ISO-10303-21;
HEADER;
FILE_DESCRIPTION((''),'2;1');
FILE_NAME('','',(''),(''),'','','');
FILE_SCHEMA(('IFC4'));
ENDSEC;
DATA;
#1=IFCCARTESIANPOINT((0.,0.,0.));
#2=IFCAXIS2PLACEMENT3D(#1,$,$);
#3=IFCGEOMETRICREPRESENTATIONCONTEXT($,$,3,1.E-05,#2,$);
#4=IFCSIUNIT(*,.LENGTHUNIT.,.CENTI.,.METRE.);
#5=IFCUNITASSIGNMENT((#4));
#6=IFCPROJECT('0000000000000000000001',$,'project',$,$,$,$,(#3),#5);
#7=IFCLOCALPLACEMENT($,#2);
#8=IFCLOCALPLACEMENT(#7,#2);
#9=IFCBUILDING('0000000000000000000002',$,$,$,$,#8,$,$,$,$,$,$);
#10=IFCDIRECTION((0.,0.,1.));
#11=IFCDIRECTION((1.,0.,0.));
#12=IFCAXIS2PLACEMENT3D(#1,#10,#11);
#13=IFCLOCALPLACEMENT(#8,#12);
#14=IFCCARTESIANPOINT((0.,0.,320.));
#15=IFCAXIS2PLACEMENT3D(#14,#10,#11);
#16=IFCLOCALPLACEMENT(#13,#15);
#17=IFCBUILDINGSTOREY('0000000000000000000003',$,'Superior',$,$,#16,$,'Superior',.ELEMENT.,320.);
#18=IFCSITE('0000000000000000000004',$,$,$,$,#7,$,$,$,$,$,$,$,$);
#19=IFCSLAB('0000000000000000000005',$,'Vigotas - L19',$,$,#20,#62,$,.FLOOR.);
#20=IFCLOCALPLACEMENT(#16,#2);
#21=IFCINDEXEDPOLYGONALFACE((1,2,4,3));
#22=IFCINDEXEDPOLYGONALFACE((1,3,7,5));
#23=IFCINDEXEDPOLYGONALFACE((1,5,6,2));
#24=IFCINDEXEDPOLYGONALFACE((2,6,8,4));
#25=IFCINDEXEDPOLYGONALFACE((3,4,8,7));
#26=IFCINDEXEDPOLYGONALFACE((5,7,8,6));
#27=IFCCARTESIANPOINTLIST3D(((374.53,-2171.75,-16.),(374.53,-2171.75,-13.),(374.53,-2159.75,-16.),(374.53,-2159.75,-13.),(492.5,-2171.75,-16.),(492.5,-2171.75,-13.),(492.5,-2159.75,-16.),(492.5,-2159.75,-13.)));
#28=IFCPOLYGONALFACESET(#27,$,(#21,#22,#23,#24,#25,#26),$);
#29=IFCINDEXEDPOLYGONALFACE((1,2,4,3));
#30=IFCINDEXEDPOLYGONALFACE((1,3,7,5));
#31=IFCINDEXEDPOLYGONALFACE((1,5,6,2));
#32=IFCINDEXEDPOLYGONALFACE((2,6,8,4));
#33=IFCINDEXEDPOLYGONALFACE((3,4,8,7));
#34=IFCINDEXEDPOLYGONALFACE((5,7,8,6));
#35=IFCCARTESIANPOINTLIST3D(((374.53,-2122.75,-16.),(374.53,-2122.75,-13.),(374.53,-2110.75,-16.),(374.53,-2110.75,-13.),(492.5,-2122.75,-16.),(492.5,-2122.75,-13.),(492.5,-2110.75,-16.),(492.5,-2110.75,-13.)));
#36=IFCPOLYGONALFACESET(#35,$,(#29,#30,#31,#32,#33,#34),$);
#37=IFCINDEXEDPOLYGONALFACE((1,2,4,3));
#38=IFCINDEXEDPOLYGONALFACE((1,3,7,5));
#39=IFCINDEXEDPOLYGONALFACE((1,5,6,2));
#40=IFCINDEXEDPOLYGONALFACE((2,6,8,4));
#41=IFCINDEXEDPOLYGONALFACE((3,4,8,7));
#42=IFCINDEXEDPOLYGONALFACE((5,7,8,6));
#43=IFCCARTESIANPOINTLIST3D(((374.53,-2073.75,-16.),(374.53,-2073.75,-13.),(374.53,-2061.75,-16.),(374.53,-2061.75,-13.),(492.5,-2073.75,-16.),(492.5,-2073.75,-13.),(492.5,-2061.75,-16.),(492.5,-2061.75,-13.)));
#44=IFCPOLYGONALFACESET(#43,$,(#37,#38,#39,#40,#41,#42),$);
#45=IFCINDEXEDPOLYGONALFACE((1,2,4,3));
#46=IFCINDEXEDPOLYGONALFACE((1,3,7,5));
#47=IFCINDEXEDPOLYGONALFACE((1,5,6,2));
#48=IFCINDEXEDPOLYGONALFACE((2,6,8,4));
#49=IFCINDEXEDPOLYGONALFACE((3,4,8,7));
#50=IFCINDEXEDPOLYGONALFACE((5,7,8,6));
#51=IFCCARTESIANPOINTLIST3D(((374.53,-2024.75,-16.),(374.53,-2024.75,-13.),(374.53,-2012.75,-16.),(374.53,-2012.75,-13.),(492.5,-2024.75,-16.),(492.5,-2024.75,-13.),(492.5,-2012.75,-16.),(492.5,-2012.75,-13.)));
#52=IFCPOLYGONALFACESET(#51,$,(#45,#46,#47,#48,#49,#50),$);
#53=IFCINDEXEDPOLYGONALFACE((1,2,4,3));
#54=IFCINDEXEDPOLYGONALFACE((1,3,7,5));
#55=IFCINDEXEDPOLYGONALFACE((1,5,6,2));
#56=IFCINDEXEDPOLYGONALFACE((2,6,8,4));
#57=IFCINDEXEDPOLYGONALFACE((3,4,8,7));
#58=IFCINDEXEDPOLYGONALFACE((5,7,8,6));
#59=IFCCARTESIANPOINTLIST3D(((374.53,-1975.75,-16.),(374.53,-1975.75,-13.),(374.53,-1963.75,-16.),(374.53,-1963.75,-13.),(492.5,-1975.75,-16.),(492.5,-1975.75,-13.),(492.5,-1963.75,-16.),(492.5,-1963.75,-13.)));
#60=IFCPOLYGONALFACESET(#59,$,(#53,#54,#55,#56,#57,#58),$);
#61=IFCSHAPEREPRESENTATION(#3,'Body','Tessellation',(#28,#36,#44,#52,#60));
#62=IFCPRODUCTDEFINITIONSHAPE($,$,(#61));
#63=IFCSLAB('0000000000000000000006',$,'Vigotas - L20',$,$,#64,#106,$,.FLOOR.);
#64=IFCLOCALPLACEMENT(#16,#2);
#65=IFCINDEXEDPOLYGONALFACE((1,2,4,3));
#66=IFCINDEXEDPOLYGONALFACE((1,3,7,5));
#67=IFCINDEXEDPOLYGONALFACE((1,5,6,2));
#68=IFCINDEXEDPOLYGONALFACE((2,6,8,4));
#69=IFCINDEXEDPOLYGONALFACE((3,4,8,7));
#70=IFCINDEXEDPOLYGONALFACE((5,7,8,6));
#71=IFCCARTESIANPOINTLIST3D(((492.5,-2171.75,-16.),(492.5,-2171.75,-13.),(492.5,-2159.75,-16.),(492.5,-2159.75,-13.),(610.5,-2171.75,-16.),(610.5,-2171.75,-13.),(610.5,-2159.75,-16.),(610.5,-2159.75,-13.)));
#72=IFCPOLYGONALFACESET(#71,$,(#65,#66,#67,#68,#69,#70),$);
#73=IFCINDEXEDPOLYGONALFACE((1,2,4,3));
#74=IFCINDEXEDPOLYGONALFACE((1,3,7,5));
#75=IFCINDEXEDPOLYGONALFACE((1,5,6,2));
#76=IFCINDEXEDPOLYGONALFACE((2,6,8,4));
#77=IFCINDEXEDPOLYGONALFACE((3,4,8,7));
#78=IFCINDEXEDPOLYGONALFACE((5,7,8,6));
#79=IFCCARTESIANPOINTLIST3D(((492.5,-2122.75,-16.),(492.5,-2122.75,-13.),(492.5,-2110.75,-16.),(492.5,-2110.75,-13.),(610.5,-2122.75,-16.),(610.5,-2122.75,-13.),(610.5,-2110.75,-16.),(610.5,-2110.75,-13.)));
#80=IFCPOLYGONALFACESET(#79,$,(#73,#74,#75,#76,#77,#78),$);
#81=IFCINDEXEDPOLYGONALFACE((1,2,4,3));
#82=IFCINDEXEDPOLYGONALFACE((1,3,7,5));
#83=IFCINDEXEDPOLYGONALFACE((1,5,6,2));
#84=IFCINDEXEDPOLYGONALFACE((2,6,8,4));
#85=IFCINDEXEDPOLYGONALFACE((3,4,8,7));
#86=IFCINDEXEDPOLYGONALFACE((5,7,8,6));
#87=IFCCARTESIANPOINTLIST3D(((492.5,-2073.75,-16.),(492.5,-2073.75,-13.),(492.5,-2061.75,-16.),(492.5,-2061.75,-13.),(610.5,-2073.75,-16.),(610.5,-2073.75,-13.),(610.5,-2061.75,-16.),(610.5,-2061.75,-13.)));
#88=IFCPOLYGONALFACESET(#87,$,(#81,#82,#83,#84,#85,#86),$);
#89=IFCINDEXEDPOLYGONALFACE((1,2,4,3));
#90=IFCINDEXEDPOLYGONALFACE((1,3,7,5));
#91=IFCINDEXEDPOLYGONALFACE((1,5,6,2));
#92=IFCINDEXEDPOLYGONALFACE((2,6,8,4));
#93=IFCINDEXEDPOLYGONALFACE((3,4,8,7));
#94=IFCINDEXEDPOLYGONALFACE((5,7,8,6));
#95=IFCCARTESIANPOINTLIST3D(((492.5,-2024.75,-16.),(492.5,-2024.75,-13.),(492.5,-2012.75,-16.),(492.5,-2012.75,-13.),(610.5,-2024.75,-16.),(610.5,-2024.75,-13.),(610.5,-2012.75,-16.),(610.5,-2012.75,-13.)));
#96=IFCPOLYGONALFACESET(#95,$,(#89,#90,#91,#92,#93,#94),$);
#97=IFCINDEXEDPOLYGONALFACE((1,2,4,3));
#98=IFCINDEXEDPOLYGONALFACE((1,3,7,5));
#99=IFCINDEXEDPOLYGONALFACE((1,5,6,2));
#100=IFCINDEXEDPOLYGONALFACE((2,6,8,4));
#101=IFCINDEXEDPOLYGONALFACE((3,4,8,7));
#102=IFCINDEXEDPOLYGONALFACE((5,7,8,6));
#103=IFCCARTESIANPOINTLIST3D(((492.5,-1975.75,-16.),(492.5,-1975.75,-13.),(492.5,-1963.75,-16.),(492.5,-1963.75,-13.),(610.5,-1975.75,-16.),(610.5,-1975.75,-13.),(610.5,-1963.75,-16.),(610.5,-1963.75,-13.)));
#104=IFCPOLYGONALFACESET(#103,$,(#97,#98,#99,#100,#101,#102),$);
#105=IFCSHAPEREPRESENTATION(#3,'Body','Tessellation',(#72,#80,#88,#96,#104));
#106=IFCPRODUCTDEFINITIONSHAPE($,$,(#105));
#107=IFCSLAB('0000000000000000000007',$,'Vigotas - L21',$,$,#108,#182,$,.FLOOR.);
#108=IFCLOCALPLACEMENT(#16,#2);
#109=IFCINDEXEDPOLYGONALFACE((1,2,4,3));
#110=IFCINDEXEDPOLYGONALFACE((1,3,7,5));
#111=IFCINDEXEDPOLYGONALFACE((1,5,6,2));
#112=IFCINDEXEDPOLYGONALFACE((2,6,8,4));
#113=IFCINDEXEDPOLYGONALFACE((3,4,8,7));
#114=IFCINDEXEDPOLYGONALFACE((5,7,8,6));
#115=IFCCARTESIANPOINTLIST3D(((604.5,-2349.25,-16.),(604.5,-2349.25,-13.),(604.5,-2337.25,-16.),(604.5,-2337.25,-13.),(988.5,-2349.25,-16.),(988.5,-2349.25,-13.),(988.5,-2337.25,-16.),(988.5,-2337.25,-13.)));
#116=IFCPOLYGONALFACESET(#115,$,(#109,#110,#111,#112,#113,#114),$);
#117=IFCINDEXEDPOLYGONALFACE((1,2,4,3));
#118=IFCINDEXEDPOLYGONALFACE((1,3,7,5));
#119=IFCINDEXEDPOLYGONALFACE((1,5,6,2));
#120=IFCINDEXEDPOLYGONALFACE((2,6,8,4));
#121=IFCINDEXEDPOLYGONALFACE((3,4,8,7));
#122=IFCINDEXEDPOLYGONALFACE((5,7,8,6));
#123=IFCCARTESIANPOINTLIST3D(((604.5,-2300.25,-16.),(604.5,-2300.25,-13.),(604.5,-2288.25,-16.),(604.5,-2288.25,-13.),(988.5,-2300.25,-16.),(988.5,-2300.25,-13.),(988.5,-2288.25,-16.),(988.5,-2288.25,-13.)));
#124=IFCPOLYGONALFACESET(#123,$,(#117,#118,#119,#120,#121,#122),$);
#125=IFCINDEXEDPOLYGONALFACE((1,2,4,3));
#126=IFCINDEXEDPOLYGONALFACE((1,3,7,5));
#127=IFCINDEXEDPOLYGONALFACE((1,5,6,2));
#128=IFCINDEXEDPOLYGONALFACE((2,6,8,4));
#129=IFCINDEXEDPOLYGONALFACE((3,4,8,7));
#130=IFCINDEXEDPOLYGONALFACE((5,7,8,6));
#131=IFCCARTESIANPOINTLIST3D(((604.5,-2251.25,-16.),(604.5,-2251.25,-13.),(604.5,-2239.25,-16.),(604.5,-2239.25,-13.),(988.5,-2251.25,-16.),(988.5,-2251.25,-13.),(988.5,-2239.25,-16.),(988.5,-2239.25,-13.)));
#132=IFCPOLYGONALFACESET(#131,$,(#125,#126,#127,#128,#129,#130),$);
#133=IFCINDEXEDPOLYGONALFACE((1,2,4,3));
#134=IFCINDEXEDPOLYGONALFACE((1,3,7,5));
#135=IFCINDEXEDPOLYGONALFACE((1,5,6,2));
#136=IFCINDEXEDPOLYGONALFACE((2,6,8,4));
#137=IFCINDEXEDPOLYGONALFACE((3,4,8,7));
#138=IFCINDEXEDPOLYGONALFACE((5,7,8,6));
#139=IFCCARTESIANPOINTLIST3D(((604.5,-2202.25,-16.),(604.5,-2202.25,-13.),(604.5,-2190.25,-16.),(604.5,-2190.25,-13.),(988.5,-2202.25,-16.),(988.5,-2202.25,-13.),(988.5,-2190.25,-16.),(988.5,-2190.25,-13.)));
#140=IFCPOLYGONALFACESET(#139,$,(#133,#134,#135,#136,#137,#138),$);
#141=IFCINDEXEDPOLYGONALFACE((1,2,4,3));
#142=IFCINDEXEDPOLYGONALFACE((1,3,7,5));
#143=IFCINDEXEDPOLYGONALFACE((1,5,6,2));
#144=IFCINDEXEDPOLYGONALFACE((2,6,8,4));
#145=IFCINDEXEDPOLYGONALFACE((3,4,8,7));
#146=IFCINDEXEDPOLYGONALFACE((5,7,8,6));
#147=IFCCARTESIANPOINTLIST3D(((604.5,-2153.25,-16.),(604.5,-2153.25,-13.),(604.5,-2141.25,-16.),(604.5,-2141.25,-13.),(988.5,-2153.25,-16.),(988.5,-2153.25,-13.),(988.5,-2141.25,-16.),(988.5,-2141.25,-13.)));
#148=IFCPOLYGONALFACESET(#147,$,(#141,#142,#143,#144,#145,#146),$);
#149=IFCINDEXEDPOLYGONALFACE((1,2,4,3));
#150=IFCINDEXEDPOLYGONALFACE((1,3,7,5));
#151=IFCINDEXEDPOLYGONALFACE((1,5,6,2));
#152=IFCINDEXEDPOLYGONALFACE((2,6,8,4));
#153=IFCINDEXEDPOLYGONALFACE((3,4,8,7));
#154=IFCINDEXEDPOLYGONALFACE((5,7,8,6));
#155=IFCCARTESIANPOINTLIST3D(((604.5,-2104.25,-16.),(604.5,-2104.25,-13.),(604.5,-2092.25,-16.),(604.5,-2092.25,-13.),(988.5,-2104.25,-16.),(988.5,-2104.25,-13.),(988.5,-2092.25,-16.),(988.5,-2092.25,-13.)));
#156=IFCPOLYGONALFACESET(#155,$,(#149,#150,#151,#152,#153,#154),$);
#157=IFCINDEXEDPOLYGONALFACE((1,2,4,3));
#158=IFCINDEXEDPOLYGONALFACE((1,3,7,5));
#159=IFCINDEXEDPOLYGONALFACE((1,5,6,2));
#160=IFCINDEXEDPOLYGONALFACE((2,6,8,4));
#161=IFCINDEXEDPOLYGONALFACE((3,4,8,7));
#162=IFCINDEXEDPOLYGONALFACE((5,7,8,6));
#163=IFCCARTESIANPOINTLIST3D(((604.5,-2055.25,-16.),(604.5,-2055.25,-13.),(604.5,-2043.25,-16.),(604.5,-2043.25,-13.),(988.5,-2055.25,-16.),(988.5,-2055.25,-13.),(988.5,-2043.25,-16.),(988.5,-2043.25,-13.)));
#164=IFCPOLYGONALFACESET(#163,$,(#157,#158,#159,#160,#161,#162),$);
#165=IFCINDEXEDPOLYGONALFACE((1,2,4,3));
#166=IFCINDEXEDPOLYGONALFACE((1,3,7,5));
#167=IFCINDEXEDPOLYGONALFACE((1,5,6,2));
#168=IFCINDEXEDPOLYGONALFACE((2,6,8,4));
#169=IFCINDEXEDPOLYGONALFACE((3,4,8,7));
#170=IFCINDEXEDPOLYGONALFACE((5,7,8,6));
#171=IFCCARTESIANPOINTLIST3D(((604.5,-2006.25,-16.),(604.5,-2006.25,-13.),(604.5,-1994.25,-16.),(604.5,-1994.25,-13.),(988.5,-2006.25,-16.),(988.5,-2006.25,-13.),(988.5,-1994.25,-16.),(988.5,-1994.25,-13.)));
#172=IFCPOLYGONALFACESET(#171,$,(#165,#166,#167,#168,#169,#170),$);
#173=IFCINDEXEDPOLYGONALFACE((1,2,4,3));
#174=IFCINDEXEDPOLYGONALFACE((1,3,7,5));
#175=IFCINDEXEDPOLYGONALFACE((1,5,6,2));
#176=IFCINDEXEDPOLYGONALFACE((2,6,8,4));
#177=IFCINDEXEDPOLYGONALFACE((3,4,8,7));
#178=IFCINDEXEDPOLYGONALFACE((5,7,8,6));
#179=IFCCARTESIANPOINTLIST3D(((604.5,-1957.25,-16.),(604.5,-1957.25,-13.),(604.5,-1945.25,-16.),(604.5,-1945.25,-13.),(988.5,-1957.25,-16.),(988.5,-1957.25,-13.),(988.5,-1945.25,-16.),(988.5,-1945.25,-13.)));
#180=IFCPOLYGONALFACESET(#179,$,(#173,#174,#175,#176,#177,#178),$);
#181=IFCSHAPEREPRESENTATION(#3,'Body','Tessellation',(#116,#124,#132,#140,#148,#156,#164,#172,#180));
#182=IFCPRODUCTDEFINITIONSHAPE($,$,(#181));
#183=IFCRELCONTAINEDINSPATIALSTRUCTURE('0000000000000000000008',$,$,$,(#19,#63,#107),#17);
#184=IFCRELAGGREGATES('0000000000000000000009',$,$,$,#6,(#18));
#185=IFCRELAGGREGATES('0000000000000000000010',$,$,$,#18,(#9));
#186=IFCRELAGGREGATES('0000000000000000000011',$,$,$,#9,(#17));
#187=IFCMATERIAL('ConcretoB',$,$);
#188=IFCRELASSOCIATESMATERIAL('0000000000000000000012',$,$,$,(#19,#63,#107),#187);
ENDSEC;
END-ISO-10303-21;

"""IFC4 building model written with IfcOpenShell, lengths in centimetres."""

from ifc_helpers import new_model, si_unit, frame, origin, origin_with_axes, place, context, project, spatial, polyline, outline, extrude, material, element, save


model = new_model("IFC4")

# Units and contexts
context_of_model = context(None, 3, precision=1e-05, world=origin())
ifc_project = project(units=[si_unit("LENGTHUNIT", "METRE", prefix="CENTI")], contexts=[context_of_model])

# Site, building, storey
site_placement = place(None, origin())
site = spatial("IfcSite", under=ifc_project, at=site_placement)
building_placement = place(site_placement, origin())
building = spatial("IfcBuilding", under=site, at=building_placement)
placement = place(building_placement, origin_with_axes())
storey_placement = place(placement, frame((0.0, 0.0, 320.0), z_axis=(0.0, 0.0, 1.0), x_axis=(1.0, 0.0, 0.0)))
storey = spatial("IfcBuildingStorey", under=building, at=storey_placement, Name="Superior", LongName="Superior", CompositionType="ELEMENT", Elevation=320.0)

# Shared definitions
ifc_material = material(Name="ConcretoB")

# Slabs
slab_1_placement = place(storey_placement, frame((433.51, -2067.75, -13.0), z_axis=(0.0, 0.0, 1.0), x_axis=(1.0, 0.0, 0.0)))
element("IfcSlab", 1, at=slab_1_placement, inside=storey, material=ifc_material, Name="Vigotas - L19", PredefinedType="FLOOR", context=context_of_model, shape_type="SolidModel", body=[
    extrude(outline(polyline([(6.0, 1.5), (-6.0, 1.5), (-6.0, -1.5), (6.0, -1.5), (6.0, 1.5), (6.0, 1.5)])), frame((-58.98, -98.0, -1.5), z_axis=(1.0, 0.0, 0.0), x_axis=(0.0, -1.0, 0.0)), (0.0, 0.0, 1.0), 117.97),
    extrude(outline(polyline([(6.0, 1.5), (-6.0, 1.5), (-6.0, -1.5), (6.0, -1.5), (6.0, 1.5), (6.0, 1.5)])), frame((-58.98, -49.0, -1.5), z_axis=(1.0, 0.0, 0.0), x_axis=(0.0, -1.0, 0.0)), (0.0, 0.0, 1.0), 117.97),
    extrude(outline(polyline([(6.0, 1.5), (-6.0, 1.5), (-6.0, -1.5), (6.0, -1.5), (6.0, 1.5), (6.0, 1.5)])), frame((-58.98, 0.0, -1.5), z_axis=(1.0, 0.0, 0.0), x_axis=(0.0, -1.0, 0.0)), (0.0, 0.0, 1.0), 117.97),
    extrude(outline(polyline([(6.0, 1.5), (-6.0, 1.5), (-6.0, -1.5), (6.0, -1.5), (6.0, 1.5), (6.0, 1.5)])), frame((-58.98, 49.0, -1.5), z_axis=(1.0, 0.0, 0.0), x_axis=(0.0, -1.0, 0.0)), (0.0, 0.0, 1.0), 117.97),
    extrude(outline(polyline([(6.0, 1.5), (-6.0, 1.5), (-6.0, -1.5), (6.0, -1.5), (6.0, 1.5), (6.0, 1.5)])), frame((-58.98, 98.0, -1.5), z_axis=(1.0, 0.0, 0.0), x_axis=(0.0, -1.0, 0.0)), (0.0, 0.0, 1.0), 117.97),
])
slab_2_placement = place(storey_placement, frame((551.5, -2067.75, -13.0), z_axis=(0.0, 0.0, 1.0), x_axis=(1.0, 0.0, 0.0)))
element("IfcSlab", 2, at=slab_2_placement, inside=storey, material=ifc_material, Name="Vigotas - L20", PredefinedType="FLOOR", context=context_of_model, shape_type="SolidModel", body=[
    extrude(outline(polyline([(6.0, 1.5), (-6.0, 1.5), (-6.0, -1.5), (6.0, -1.5), (6.0, 1.5), (6.0, 1.5)])), frame((-59.0, -98.0, -1.5), z_axis=(1.0, 0.0, 0.0), x_axis=(0.0, -1.0, 0.0)), (0.0, 0.0, 1.0), 118.0),
    extrude(outline(polyline([(6.0, 1.5), (-6.0, 1.5), (-6.0, -1.5), (6.0, -1.5), (6.0, 1.5), (6.0, 1.5)])), frame((-59.0, -49.0, -1.5), z_axis=(1.0, 0.0, 0.0), x_axis=(0.0, -1.0, 0.0)), (0.0, 0.0, 1.0), 118.0),
    extrude(outline(polyline([(6.0, 1.5), (-6.0, 1.5), (-6.0, -1.5), (6.0, -1.5), (6.0, 1.5), (6.0, 1.5)])), frame((-59.0, 0.0, -1.5), z_axis=(1.0, 0.0, 0.0), x_axis=(0.0, -1.0, 0.0)), (0.0, 0.0, 1.0), 118.0),
    extrude(outline(polyline([(6.0, 1.5), (-6.0, 1.5), (-6.0, -1.5), (6.0, -1.5), (6.0, 1.5), (6.0, 1.5)])), frame((-59.0, 49.0, -1.5), z_axis=(1.0, 0.0, 0.0), x_axis=(0.0, -1.0, 0.0)), (0.0, 0.0, 1.0), 118.0),
    extrude(outline(polyline([(6.0, 1.5), (-6.0, 1.5), (-6.0, -1.5), (6.0, -1.5), (6.0, 1.5), (6.0, 1.5)])), frame((-59.0, 98.0, -1.5), z_axis=(1.0, 0.0, 0.0), x_axis=(0.0, -1.0, 0.0)), (0.0, 0.0, 1.0), 118.0),
])
slab_3_placement = place(storey_placement, frame((796.5, -2147.25, -13.0), z_axis=(0.0, 0.0, 1.0), x_axis=(1.0, 0.0, 0.0)))
element("IfcSlab", 3, at=slab_3_placement, inside=storey, material=ifc_material, Name="Vigotas - L21", PredefinedType="FLOOR", context=context_of_model, shape_type="SolidModel", body=[
    extrude(outline(polyline([(6.0, 1.5), (-6.0, 1.5), (-6.0, -1.5), (6.0, -1.5), (6.0, 1.5), (6.0, 1.5)])), frame((-192.0, -196.0, -1.5), z_axis=(1.0, 0.0, 0.0), x_axis=(0.0, -1.0, 0.0)), (0.0, 0.0, 1.0), 384.0),
    extrude(outline(polyline([(6.0, 1.5), (-6.0, 1.5), (-6.0, -1.5), (6.0, -1.5), (6.0, 1.5), (6.0, 1.5)])), frame((-192.0, -147.0, -1.5), z_axis=(1.0, 0.0, 0.0), x_axis=(0.0, -1.0, 0.0)), (0.0, 0.0, 1.0), 384.0),
    extrude(outline(polyline([(6.0, 1.5), (-6.0, 1.5), (-6.0, -1.5), (6.0, -1.5), (6.0, 1.5), (6.0, 1.5)])), frame((-192.0, -98.0, -1.5), z_axis=(1.0, 0.0, 0.0), x_axis=(0.0, -1.0, 0.0)), (0.0, 0.0, 1.0), 384.0),
    extrude(outline(polyline([(6.0, 1.5), (-6.0, 1.5), (-6.0, -1.5), (6.0, -1.5), (6.0, 1.5), (6.0, 1.5)])), frame((-192.0, -49.0, -1.5), z_axis=(1.0, 0.0, 0.0), x_axis=(0.0, -1.0, 0.0)), (0.0, 0.0, 1.0), 384.0),
    extrude(outline(polyline([(6.0, 1.5), (-6.0, 1.5), (-6.0, -1.5), (6.0, -1.5), (6.0, 1.5), (6.0, 1.5)])), frame((-192.0, 0.0, -1.5), z_axis=(1.0, 0.0, 0.0), x_axis=(0.0, -1.0, 0.0)), (0.0, 0.0, 1.0), 384.0),
    extrude(outline(polyline([(6.0, 1.5), (-6.0, 1.5), (-6.0, -1.5), (6.0, -1.5), (6.0, 1.5), (6.0, 1.5)])), frame((-192.0, 49.0, -1.5), z_axis=(1.0, 0.0, 0.0), x_axis=(0.0, -1.0, 0.0)), (0.0, 0.0, 1.0), 384.0),
    extrude(outline(polyline([(6.0, 1.5), (-6.0, 1.5), (-6.0, -1.5), (6.0, -1.5), (6.0, 1.5), (6.0, 1.5)])), frame((-192.0, 98.0, -1.5), z_axis=(1.0, 0.0, 0.0), x_axis=(0.0, -1.0, 0.0)), (0.0, 0.0, 1.0), 384.0),
    extrude(outline(polyline([(6.0, 1.5), (-6.0, 1.5), (-6.0, -1.5), (6.0, -1.5), (6.0, 1.5), (6.0, 1.5)])), frame((-192.0, 147.0, -1.5), z_axis=(1.0, 0.0, 0.0), x_axis=(0.0, -1.0, 0.0)), (0.0, 0.0, 1.0), 384.0),
    extrude(outline(polyline([(6.0, 1.5), (-6.0, 1.5), (-6.0, -1.5), (6.0, -1.5), (6.0, 1.5), (6.0, 1.5)])), frame((-192.0, 196.0, -1.5), z_axis=(1.0, 0.0, 0.0), x_axis=(0.0, -1.0, 0.0)), (0.0, 0.0, 1.0), 384.0),
])

save(model, "model.ifc")
